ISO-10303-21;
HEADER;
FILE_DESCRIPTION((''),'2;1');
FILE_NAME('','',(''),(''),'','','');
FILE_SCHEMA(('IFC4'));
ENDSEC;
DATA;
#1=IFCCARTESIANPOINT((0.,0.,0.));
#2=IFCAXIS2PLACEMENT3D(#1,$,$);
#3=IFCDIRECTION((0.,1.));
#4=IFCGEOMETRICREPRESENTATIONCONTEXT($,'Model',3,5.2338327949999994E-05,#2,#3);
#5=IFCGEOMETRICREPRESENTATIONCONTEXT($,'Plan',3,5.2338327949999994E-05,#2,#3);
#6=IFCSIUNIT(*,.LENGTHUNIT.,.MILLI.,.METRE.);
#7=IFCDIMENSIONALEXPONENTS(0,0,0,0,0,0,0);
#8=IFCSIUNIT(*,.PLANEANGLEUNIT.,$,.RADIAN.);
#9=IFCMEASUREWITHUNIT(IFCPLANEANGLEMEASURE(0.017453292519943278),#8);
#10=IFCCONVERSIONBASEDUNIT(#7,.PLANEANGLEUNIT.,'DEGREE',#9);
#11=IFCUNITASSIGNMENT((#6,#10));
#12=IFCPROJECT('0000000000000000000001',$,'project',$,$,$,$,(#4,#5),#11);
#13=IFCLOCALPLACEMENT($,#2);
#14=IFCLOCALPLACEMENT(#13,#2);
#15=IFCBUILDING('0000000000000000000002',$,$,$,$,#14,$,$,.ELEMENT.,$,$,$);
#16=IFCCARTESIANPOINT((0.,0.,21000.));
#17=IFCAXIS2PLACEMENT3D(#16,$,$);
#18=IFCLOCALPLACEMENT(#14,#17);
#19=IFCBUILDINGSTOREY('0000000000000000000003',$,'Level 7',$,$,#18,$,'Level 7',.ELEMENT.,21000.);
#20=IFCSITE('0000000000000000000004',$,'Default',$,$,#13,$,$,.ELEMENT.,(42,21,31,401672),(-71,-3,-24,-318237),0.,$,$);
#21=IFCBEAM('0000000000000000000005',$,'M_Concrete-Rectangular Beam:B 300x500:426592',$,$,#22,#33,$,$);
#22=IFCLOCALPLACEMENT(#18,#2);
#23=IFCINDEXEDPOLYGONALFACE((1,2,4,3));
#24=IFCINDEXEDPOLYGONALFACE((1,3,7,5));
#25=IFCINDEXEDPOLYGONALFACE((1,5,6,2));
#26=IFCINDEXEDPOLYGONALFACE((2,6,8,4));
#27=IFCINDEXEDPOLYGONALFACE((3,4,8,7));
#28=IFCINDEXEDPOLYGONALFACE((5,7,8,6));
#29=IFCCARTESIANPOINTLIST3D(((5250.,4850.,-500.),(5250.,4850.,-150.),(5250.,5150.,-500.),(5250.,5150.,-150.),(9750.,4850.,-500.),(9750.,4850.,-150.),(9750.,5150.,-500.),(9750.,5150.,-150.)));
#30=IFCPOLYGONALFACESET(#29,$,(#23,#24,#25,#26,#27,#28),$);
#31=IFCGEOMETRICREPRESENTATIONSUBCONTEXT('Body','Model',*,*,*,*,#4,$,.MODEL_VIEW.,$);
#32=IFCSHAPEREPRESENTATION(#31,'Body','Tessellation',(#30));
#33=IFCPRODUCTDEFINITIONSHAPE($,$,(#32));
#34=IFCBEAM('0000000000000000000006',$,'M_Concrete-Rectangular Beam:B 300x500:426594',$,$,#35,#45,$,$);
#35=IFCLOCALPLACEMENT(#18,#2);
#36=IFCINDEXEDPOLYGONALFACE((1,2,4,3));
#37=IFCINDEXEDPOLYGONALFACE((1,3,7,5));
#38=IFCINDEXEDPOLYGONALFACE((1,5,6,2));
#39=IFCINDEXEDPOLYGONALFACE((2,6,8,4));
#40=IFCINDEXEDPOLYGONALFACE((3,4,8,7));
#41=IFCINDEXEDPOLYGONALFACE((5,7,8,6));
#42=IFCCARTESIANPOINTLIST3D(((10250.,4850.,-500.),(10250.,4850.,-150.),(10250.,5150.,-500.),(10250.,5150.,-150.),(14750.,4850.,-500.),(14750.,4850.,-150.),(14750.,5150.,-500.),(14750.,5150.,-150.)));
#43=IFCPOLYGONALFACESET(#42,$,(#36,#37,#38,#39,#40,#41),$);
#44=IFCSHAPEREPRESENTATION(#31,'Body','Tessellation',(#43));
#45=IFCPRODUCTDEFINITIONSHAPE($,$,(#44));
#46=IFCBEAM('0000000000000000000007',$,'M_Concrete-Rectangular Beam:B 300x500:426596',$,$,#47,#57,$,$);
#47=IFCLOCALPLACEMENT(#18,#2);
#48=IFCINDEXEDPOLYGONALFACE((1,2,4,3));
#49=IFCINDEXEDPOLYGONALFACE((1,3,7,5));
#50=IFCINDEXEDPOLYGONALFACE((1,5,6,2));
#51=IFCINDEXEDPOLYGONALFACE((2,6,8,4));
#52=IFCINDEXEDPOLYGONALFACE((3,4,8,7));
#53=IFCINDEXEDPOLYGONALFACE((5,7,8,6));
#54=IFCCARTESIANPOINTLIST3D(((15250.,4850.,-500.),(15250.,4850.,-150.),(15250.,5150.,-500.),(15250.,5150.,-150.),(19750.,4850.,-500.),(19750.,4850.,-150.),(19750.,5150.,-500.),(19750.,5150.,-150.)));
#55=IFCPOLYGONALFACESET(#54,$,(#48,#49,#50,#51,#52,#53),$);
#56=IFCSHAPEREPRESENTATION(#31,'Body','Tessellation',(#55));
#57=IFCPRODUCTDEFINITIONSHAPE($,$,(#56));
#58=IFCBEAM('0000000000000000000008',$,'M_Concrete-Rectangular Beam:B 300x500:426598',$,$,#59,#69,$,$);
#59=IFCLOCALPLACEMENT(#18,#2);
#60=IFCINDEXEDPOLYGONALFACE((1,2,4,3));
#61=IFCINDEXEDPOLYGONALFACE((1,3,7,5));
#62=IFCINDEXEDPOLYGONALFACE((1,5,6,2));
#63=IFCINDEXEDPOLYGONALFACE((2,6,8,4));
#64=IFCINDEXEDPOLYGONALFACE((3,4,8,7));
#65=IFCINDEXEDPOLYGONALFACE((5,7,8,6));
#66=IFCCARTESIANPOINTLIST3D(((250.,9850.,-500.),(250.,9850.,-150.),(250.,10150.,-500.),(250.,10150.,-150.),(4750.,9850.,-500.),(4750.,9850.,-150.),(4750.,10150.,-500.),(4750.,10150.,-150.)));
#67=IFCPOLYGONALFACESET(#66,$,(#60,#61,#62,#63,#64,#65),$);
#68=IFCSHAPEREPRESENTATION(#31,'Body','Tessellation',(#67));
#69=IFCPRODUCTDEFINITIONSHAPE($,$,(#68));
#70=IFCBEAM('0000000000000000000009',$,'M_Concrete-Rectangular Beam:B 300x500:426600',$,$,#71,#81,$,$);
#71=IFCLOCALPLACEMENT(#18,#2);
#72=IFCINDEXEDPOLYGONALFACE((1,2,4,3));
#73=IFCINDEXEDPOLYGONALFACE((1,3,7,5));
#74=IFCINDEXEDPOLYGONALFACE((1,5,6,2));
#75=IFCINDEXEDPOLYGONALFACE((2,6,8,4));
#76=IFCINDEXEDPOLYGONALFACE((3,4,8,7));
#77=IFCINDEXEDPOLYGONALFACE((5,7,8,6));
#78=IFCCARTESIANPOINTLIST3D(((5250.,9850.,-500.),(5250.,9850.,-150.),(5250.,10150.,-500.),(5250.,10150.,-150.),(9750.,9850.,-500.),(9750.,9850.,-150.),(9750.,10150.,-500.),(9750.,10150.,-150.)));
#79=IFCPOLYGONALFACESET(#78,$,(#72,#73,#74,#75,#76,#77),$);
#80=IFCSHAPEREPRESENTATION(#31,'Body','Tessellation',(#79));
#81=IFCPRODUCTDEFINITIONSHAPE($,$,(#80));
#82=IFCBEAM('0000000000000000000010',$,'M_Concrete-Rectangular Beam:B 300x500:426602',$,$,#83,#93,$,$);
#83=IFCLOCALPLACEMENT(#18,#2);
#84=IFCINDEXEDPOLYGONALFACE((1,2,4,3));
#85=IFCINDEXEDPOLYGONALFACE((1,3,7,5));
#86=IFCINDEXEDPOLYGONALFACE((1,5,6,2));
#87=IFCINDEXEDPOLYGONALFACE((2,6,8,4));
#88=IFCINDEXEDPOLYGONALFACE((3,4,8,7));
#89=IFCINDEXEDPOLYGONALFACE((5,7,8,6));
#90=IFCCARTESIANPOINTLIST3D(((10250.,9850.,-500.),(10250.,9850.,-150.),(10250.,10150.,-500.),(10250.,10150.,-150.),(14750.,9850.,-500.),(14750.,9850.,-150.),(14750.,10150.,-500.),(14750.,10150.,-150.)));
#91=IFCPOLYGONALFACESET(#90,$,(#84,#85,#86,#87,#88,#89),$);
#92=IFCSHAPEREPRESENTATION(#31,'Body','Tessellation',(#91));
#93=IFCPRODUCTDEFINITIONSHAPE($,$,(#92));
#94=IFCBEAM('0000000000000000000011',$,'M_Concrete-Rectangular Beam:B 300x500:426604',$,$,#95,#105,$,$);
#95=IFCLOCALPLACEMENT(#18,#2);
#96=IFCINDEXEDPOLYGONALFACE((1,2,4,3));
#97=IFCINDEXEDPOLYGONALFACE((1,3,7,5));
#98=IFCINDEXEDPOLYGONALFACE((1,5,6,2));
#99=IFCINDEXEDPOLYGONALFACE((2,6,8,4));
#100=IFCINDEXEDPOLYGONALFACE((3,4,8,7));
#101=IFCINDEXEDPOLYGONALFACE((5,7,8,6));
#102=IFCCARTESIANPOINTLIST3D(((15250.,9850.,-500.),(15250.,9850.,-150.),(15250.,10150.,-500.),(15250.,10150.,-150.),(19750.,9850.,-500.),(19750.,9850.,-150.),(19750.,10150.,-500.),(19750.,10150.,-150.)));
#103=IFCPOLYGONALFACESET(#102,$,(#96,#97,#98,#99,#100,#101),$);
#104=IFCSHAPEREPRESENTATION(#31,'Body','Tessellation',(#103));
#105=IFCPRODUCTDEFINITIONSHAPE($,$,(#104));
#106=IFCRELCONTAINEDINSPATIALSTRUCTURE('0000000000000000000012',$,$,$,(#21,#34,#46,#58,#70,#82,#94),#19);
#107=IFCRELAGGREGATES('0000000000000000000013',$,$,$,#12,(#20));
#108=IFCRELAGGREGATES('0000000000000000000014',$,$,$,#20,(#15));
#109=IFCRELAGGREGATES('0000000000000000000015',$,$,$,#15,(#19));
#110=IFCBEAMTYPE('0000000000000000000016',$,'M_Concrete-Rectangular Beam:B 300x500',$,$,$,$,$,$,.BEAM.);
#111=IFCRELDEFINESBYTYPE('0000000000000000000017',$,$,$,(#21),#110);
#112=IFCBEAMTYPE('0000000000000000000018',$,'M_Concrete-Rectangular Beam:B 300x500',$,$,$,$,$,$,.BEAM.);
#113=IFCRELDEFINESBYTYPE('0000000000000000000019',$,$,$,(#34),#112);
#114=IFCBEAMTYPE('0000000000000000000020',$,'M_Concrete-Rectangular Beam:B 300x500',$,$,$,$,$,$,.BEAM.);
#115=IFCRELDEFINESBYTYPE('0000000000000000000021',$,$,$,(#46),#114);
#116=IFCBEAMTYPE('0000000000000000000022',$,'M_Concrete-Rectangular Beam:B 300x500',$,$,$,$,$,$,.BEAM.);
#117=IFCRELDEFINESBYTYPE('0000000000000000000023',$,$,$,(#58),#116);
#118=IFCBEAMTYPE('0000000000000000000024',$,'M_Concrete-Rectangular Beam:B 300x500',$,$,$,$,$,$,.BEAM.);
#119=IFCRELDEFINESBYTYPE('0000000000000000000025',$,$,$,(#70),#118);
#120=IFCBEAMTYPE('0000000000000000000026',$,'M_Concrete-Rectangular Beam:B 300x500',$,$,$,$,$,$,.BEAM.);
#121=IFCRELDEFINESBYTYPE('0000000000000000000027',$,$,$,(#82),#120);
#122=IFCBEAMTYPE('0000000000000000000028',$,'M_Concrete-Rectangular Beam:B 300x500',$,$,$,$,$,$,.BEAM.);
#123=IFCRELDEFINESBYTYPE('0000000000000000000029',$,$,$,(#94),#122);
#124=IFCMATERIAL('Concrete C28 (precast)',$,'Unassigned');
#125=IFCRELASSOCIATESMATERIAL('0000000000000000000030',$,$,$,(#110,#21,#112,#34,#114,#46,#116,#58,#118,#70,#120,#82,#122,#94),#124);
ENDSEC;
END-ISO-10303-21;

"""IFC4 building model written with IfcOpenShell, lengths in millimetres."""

from ifc_helpers import new_model, entity, si_unit, converted_unit, direction, frame, origin, place, context, subcontext, project, spatial, indexed_curve, outline, extrude, source, transform, mapped, material, type_object, type_shapes, element, save


model = new_model("IFC4")

# Units and contexts
model_context = context("Model", 3, precision=5.2338327949999994e-05, world=origin(), true_north=direction((0.0, 1.0)))
plan_context = context("Plan", 3, precision=5.2338327949999994e-05, world=origin(), true_north=direction((0.0, 1.0)))
body_context = subcontext(model_context, "Body", "Model", "MODEL_VIEW")
ifc_project = project(units=[si_unit("LENGTHUNIT", "METRE", prefix="MILLI"), converted_unit("PLANEANGLEUNIT", "DEGREE", entity("IfcPlaneAngleMeasure", 0.017453292519943278), si_unit("PLANEANGLEUNIT", "RADIAN"), dimensions=[0, 0, 0, 0, 0, 0, 0])], contexts=[model_context, plan_context])

# Site, building, storey
site_placement = place(None, origin())
site = spatial("IfcSite", under=ifc_project, at=site_placement, Name="Default", CompositionType="ELEMENT", RefLatitude=(42, 21, 31, 401672), RefLongitude=(-71, -3, -24, -318237), RefElevation=0.0)
building_placement = place(site_placement, origin())
building = spatial("IfcBuilding", under=site, at=building_placement, CompositionType="ELEMENT")
storey_placement = place(building_placement, frame((0.0, 0.0, 21000.0)))
storey = spatial("IfcBuildingStorey", under=building, at=storey_placement, Name="Level 7", LongName="Level 7", CompositionType="ELEMENT", Elevation=21000.0)

# Shared definitions
ifc_material = material(Name="Concrete C28 (precast)", Category="Unassigned")

# Beams
beam_type_1 = type_object("IfcBeamType", Name="M_Concrete-Rectangular Beam:B 300x500", PredefinedType="BEAM", material=ifc_material)
shared_shape_1 = source(origin(), body_context, "Body", "SweptSolid", [
    extrude(outline(indexed_curve([(-175.0, -150.0), (175.0, -150.0), (175.0, 150.0), (-175.0, 150.0), (-175.0, -150.0)], self_intersect=False)), frame((5250.0, 5000.0, 20675.0), z_axis=(1.0, 0.0, 0.0), x_axis=(0.0, 0.0, -1.0)), (0.0, 0.0, 1.0), 4500.0),
])
type_shapes(beam_type_1, [shared_shape_1])
beam_1_placement = place(storey_placement, frame((0.0, 0.0, -21000.0)))
element("IfcBeam", 1, at=beam_1_placement, inside=storey, type_object=beam_type_1, material=ifc_material, Name="M_Concrete-Rectangular Beam:B 300x500:426592", context=body_context, shape_type="MappedRepresentation", body=[
    mapped(shared_shape_1, transform((0.0, 0.0, 0.0), scale=1.0)),
])
beam_type_2 = type_object("IfcBeamType", Name="M_Concrete-Rectangular Beam:B 300x500", PredefinedType="BEAM", material=ifc_material)
shared_shape_2 = source(origin(), body_context, "Body", "SweptSolid", [
    extrude(outline(indexed_curve([(-175.0, -150.0), (175.0, -150.0), (175.0, 150.0), (-175.0, 150.0), (-175.0, -150.0)], self_intersect=False)), frame((10250.0, 5000.0, 20675.0), z_axis=(1.0, 0.0, 0.0), x_axis=(0.0, 0.0, -1.0)), (0.0, 0.0, 1.0), 4500.0),
])
type_shapes(beam_type_2, [shared_shape_2])
beam_2_placement = place(storey_placement, frame((0.0, 0.0, -21000.0)))
element("IfcBeam", 2, at=beam_2_placement, inside=storey, type_object=beam_type_2, material=ifc_material, Name="M_Concrete-Rectangular Beam:B 300x500:426594", context=body_context, shape_type="MappedRepresentation", body=[
    mapped(shared_shape_2, transform((0.0, 0.0, 0.0), scale=1.0)),
])
beam_type_3 = type_object("IfcBeamType", Name="M_Concrete-Rectangular Beam:B 300x500", PredefinedType="BEAM", material=ifc_material)
shared_shape_3 = source(origin(), body_context, "Body", "SweptSolid", [
    extrude(outline(indexed_curve([(-175.0, -150.0), (175.0, -150.0), (175.0, 150.0), (-175.0, 150.0), (-175.0, -150.0)], self_intersect=False)), frame((15250.0, 5000.0, 20675.0), z_axis=(1.0, 0.0, 0.0), x_axis=(0.0, 0.0, -1.0)), (0.0, 0.0, 1.0), 4500.0),
])
type_shapes(beam_type_3, [shared_shape_3])
beam_3_placement = place(storey_placement, frame((0.0, 0.0, -21000.0)))
element("IfcBeam", 3, at=beam_3_placement, inside=storey, type_object=beam_type_3, material=ifc_material, Name="M_Concrete-Rectangular Beam:B 300x500:426596", context=body_context, shape_type="MappedRepresentation", body=[
    mapped(shared_shape_3, transform((0.0, 0.0, 0.0), scale=1.0)),
])
beam_type_4 = type_object("IfcBeamType", Name="M_Concrete-Rectangular Beam:B 300x500", PredefinedType="BEAM", material=ifc_material)
shared_shape_4 = source(origin(), body_context, "Body", "SweptSolid", [
    extrude(outline(indexed_curve([(-175.0, -150.0), (175.0, -150.0), (175.0, 150.0), (-175.0, 150.0), (-175.0, -150.0)], self_intersect=False)), frame((250.0, 10000.0, 20675.0), z_axis=(1.0, 0.0, 0.0), x_axis=(0.0, 0.0, -1.0)), (0.0, 0.0, 1.0), 4500.0),
])
type_shapes(beam_type_4, [shared_shape_4])
beam_4_placement = place(storey_placement, frame((0.0, 0.0, -21000.0)))
element("IfcBeam", 4, at=beam_4_placement, inside=storey, type_object=beam_type_4, material=ifc_material, Name="M_Concrete-Rectangular Beam:B 300x500:426598", context=body_context, shape_type="MappedRepresentation", body=[
    mapped(shared_shape_4, transform((0.0, 0.0, 0.0), scale=1.0)),
])
beam_type_5 = type_object("IfcBeamType", Name="M_Concrete-Rectangular Beam:B 300x500", PredefinedType="BEAM", material=ifc_material)
shared_shape_5 = source(origin(), body_context, "Body", "SweptSolid", [
    extrude(outline(indexed_curve([(-175.0, -150.0), (175.0, -150.0), (175.0, 150.0), (-175.0, 150.0), (-175.0, -150.0)], self_intersect=False)), frame((5250.0, 10000.0, 20675.0), z_axis=(1.0, 0.0, 0.0), x_axis=(0.0, 0.0, -1.0)), (0.0, 0.0, 1.0), 4500.0),
])
type_shapes(beam_type_5, [shared_shape_5])
beam_5_placement = place(storey_placement, frame((0.0, 0.0, -21000.0)))
element("IfcBeam", 5, at=beam_5_placement, inside=storey, type_object=beam_type_5, material=ifc_material, Name="M_Concrete-Rectangular Beam:B 300x500:426600", context=body_context, shape_type="MappedRepresentation", body=[
    mapped(shared_shape_5, transform((0.0, 0.0, 0.0), scale=1.0)),
])
beam_type_6 = type_object("IfcBeamType", Name="M_Concrete-Rectangular Beam:B 300x500", PredefinedType="BEAM", material=ifc_material)
shared_shape_6 = source(origin(), body_context, "Body", "SweptSolid", [
    extrude(outline(indexed_curve([(-175.0, -150.0), (175.0, -150.0), (175.0, 150.0), (-175.0, 150.0), (-175.0, -150.0)], self_intersect=False)), frame((10250.0, 10000.0, 20675.0), z_axis=(1.0, 0.0, 0.0), x_axis=(0.0, 0.0, -1.0)), (0.0, 0.0, 1.0), 4500.0),
])
type_shapes(beam_type_6, [shared_shape_6])
beam_6_placement = place(storey_placement, frame((0.0, 0.0, -21000.0)))
element("IfcBeam", 6, at=beam_6_placement, inside=storey, type_object=beam_type_6, material=ifc_material, Name="M_Concrete-Rectangular Beam:B 300x500:426602", context=body_context, shape_type="MappedRepresentation", body=[
    mapped(shared_shape_6, transform((0.0, 0.0, 0.0), scale=1.0)),
])
beam_type_7 = type_object("IfcBeamType", Name="M_Concrete-Rectangular Beam:B 300x500", PredefinedType="BEAM", material=ifc_material)
shared_shape_7 = source(origin(), body_context, "Body", "SweptSolid", [
    extrude(outline(indexed_curve([(-175.0, -150.0), (175.0, -150.0), (175.0, 150.0), (-175.0, 150.0), (-175.0, -150.0)], self_intersect=False)), frame((15250.0, 10000.0, 20675.0), z_axis=(1.0, 0.0, 0.0), x_axis=(0.0, 0.0, -1.0)), (0.0, 0.0, 1.0), 4500.0),
])
type_shapes(beam_type_7, [shared_shape_7])
beam_7_placement = place(storey_placement, frame((0.0, 0.0, -21000.0)))
element("IfcBeam", 7, at=beam_7_placement, inside=storey, type_object=beam_type_7, material=ifc_material, Name="M_Concrete-Rectangular Beam:B 300x500:426604", context=body_context, shape_type="MappedRepresentation", body=[
    mapped(shared_shape_7, transform((0.0, 0.0, 0.0), scale=1.0)),
])

save(model, "model.ifc")
